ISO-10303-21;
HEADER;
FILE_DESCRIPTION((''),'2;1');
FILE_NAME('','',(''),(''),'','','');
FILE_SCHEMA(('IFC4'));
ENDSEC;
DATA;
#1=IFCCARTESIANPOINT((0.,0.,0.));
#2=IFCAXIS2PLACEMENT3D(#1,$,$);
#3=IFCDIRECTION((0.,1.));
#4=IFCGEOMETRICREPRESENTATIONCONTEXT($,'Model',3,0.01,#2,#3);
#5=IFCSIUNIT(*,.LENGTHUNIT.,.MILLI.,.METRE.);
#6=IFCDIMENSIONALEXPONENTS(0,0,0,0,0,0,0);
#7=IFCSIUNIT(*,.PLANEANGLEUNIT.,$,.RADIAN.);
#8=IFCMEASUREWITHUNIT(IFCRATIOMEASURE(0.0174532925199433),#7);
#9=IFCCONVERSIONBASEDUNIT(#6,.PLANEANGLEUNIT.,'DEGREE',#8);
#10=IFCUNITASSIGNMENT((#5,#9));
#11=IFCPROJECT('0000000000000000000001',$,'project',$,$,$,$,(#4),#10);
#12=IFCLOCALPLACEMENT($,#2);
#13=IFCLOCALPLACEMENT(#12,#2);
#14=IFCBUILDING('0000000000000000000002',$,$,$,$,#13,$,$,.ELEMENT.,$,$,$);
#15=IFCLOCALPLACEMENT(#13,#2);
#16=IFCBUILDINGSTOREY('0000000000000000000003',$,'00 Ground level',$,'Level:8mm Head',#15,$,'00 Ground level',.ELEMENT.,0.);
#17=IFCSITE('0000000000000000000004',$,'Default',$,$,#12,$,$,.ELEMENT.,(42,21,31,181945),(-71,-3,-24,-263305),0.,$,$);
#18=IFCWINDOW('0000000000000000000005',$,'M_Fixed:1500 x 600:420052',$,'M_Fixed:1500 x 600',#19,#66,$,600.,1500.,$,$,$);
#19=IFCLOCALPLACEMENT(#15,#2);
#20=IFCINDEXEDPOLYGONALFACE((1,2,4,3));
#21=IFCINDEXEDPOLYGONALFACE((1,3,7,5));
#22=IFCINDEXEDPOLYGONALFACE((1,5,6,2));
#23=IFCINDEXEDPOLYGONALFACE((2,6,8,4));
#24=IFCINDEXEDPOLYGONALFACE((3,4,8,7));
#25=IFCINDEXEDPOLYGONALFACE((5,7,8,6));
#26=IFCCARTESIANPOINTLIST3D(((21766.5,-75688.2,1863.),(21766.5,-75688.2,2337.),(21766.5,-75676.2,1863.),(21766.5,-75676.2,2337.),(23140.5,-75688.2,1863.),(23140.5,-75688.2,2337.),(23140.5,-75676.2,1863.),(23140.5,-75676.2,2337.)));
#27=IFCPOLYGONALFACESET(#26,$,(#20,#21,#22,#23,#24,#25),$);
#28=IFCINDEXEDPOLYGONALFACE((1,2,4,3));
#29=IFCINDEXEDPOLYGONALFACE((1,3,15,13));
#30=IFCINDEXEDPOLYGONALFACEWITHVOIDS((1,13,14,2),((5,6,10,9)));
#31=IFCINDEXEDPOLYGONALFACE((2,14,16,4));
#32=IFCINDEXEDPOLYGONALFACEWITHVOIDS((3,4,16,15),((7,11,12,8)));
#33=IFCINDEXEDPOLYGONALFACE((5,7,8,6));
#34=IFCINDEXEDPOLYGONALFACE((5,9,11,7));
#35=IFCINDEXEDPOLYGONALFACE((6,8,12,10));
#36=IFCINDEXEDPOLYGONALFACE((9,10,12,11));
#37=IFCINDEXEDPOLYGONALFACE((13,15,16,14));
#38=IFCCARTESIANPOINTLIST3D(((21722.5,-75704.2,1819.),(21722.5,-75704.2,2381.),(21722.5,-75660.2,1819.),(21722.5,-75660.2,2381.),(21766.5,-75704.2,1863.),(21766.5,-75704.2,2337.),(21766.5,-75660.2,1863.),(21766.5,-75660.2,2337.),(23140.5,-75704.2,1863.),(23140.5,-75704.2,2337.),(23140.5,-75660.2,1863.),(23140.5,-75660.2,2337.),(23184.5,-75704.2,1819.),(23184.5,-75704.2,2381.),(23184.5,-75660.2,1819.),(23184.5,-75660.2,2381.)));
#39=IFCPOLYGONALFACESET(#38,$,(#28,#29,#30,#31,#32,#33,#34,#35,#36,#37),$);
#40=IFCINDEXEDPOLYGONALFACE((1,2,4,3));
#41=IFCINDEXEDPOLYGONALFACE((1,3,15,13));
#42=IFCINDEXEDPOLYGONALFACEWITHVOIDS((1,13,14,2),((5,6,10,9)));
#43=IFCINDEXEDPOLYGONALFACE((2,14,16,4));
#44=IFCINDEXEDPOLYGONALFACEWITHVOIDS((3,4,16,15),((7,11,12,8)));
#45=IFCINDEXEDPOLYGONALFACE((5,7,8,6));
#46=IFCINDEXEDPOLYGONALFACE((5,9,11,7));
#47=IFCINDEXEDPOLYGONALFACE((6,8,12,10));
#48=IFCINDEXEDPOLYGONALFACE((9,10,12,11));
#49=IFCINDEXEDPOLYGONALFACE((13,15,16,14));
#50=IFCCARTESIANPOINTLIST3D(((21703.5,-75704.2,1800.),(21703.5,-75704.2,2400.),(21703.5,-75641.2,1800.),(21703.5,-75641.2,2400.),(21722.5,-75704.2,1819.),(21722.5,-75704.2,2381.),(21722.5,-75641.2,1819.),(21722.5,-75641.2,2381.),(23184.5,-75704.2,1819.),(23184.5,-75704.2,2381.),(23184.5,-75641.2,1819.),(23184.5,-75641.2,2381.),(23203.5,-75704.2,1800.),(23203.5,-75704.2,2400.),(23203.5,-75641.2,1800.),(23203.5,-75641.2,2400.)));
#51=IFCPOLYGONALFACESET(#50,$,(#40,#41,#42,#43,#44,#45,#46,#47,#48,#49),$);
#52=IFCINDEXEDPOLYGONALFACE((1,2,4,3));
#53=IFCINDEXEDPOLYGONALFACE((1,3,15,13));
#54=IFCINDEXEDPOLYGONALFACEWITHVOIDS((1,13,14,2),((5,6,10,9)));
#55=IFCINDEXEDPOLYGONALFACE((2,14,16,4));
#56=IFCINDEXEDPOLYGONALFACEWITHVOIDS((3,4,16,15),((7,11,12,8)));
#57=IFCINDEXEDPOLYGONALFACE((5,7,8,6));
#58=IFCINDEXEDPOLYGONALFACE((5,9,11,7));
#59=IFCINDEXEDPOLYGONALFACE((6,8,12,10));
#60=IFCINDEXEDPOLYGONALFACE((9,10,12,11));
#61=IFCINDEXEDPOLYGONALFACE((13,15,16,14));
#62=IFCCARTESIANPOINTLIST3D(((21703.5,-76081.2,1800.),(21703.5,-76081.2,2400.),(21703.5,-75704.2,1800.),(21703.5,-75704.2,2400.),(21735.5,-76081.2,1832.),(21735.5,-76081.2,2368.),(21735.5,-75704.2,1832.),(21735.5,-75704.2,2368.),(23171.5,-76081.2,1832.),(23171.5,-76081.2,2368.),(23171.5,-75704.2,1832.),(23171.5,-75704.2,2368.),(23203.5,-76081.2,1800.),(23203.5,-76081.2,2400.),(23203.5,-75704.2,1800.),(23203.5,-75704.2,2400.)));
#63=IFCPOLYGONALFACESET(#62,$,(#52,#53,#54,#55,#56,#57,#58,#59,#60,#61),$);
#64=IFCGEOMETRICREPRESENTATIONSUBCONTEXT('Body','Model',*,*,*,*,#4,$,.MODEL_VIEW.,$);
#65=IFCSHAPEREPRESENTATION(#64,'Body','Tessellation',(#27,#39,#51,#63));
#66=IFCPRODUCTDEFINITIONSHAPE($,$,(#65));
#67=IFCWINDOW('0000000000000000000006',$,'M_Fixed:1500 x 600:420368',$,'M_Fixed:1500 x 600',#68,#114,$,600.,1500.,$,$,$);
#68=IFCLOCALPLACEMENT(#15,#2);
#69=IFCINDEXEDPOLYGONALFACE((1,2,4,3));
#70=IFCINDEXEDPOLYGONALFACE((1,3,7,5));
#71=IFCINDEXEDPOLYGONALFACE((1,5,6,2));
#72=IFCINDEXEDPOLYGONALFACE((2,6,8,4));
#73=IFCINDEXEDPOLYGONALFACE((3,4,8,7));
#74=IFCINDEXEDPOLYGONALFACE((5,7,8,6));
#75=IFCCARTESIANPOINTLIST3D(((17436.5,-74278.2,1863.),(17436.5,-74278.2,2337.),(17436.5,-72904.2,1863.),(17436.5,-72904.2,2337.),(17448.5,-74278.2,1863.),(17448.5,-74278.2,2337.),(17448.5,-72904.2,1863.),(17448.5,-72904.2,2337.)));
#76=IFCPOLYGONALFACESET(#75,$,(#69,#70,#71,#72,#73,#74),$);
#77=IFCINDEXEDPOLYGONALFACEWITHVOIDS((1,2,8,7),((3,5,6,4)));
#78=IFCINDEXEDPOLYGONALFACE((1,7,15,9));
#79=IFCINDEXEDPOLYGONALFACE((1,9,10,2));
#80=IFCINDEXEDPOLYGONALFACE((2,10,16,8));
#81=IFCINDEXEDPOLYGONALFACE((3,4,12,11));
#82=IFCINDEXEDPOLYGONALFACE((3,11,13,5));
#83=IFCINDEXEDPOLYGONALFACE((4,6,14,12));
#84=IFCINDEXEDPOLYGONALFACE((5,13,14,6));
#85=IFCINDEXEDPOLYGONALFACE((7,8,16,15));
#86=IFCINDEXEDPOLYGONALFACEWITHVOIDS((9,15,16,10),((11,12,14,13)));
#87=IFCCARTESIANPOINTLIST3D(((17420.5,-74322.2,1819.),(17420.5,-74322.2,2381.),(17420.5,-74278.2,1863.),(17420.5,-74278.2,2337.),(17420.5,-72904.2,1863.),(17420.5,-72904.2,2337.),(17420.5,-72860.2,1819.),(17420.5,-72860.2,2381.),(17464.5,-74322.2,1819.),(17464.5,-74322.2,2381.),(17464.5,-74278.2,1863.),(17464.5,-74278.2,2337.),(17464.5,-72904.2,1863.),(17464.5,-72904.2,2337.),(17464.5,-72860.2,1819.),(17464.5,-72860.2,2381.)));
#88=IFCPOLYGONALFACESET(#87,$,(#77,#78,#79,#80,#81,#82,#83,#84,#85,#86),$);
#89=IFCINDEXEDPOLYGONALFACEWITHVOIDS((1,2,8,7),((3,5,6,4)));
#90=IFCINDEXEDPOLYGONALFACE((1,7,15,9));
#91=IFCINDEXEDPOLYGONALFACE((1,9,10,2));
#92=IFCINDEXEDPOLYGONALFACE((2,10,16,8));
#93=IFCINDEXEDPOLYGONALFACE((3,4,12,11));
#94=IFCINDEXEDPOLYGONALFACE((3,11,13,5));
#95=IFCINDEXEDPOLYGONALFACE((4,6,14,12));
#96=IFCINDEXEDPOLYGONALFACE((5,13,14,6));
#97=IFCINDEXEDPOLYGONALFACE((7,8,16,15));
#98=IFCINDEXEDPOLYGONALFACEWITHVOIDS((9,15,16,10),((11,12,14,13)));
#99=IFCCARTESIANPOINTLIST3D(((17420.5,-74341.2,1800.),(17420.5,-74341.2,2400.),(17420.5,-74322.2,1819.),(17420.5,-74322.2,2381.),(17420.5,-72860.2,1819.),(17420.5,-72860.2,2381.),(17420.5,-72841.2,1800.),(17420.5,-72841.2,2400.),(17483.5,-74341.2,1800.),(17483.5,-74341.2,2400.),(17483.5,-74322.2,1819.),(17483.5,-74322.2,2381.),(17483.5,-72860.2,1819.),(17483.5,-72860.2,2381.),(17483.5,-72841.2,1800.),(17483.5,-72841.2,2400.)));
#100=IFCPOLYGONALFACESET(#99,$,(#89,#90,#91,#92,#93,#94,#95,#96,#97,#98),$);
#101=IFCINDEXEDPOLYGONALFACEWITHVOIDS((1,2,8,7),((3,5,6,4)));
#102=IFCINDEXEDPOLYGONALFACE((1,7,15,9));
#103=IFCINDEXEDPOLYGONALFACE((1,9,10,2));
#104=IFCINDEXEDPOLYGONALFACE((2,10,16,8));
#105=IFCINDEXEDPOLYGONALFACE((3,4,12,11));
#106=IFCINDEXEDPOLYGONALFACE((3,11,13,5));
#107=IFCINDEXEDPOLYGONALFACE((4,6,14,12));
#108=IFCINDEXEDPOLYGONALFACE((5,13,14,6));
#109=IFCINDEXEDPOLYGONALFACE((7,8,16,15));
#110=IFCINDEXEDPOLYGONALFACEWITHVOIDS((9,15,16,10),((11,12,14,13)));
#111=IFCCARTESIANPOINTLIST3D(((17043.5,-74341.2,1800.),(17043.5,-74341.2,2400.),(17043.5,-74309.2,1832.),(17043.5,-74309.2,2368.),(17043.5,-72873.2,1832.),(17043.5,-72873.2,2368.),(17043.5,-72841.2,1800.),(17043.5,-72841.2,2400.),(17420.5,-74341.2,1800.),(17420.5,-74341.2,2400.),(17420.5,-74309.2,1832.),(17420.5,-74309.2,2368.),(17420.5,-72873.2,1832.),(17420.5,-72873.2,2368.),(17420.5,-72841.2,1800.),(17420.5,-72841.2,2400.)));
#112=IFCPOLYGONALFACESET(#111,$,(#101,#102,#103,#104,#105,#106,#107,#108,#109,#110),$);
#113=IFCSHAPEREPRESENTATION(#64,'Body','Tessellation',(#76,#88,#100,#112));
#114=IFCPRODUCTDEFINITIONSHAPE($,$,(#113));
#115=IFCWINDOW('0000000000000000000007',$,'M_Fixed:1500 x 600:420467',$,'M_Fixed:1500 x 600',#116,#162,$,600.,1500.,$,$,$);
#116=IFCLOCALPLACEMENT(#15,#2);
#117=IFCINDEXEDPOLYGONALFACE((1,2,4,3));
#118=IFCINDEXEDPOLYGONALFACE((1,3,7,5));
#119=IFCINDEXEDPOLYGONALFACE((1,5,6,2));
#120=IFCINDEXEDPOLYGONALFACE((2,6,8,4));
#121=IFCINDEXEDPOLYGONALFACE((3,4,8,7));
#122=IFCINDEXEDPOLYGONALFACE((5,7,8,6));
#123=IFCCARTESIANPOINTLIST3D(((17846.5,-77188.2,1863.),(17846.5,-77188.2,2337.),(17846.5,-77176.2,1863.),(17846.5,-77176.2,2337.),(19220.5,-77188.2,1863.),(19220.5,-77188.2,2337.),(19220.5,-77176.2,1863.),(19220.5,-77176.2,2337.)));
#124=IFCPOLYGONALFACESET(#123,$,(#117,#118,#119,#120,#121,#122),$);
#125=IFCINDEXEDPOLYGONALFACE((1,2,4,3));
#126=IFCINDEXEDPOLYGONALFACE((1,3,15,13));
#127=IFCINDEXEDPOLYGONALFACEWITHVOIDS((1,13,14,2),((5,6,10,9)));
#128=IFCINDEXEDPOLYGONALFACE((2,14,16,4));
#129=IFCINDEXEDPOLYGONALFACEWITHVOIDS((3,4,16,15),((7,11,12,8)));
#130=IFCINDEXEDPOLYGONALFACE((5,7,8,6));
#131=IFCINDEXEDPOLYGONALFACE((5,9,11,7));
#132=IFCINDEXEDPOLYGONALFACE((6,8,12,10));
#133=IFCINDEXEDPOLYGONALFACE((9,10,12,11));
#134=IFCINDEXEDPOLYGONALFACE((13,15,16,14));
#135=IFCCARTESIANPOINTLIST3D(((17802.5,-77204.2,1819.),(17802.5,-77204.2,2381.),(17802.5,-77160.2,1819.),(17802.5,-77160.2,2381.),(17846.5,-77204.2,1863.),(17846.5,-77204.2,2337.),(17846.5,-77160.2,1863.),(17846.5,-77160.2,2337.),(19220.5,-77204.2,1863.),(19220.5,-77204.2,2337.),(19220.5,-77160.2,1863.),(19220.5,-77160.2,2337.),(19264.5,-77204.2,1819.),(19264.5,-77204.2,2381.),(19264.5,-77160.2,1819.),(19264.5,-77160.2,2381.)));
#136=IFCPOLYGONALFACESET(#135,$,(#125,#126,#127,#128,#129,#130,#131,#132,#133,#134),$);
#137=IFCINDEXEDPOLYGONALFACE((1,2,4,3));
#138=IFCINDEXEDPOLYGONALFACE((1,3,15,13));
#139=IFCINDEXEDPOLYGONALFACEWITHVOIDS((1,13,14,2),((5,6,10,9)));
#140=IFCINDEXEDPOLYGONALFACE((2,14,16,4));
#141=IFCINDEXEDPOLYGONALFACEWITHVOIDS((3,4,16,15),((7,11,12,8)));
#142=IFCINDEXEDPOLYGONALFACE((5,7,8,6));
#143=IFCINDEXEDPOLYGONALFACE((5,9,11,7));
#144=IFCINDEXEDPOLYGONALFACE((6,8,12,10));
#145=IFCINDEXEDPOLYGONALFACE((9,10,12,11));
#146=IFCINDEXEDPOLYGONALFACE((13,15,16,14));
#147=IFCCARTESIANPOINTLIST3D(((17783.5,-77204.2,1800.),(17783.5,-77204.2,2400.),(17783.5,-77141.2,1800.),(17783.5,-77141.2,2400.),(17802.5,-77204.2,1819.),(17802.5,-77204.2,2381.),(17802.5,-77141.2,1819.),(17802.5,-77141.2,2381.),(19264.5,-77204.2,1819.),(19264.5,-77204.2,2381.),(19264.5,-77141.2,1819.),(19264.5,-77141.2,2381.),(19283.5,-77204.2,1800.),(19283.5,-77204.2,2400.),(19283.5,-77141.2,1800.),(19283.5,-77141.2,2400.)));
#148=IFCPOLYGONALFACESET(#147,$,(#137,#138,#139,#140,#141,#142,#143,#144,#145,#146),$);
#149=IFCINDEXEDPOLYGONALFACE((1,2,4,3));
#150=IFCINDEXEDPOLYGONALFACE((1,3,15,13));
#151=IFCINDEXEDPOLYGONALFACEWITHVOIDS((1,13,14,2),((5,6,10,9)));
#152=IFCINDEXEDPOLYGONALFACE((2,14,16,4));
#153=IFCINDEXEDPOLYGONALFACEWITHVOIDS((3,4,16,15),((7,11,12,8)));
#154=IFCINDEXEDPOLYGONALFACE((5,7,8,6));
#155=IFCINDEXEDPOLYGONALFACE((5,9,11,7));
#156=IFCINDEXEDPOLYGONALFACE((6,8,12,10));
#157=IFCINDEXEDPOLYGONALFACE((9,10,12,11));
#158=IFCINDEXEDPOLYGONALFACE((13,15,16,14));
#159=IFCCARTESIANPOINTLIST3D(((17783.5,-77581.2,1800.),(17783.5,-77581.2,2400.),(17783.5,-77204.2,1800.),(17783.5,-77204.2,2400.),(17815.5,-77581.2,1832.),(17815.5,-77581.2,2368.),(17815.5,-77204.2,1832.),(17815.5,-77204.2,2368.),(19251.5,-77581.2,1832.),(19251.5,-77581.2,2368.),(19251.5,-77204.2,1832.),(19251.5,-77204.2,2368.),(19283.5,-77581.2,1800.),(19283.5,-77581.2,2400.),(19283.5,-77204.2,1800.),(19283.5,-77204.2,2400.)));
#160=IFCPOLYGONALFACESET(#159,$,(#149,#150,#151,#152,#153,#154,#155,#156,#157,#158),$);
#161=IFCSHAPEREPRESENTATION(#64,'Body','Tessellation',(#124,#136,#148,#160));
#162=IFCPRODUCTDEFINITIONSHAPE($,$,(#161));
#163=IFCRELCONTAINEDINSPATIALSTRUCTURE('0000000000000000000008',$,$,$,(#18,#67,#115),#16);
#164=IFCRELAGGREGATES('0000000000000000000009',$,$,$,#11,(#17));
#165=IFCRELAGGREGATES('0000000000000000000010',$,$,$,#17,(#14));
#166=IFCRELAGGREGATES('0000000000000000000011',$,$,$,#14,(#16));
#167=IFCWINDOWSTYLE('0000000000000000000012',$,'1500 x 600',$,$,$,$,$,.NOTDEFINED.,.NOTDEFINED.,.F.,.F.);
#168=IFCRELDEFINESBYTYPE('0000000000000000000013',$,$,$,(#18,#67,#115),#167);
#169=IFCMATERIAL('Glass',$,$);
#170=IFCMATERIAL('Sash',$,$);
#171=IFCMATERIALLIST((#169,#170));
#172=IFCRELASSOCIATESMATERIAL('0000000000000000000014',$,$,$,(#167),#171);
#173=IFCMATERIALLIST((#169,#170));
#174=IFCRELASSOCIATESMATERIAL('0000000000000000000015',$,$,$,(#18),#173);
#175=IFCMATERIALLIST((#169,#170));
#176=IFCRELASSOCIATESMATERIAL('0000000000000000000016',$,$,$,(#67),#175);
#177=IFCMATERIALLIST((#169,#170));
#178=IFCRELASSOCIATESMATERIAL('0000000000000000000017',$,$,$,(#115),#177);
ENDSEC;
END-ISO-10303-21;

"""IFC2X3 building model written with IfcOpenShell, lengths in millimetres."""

from ifc_helpers import new_model, entity, si_unit, converted_unit, direction, frame, origin, origin_2d_with_axis, place, context, subcontext, project, spatial, polyline, rectangle, outline, extrude, source, transform, mapped, material, material_list, type_object, type_shapes, element, save


model = new_model("IFC2X3")

# Units and contexts
model_context = context("Model", 3, precision=0.01, world=origin(), true_north=direction((0.0, 1.0)))
body_context = subcontext(model_context, "Body", "Model", "MODEL_VIEW")
ifc_project = project(units=[si_unit("LENGTHUNIT", "METRE", prefix="MILLI"), converted_unit("PLANEANGLEUNIT", "DEGREE", entity("IfcRatioMeasure", 0.0174532925199433), si_unit("PLANEANGLEUNIT", "RADIAN"), dimensions=[0, 0, 0, 0, 0, 0, 0])], contexts=[model_context])

# Site, building, storey
site_placement = place(None, origin())
site = spatial("IfcSite", under=ifc_project, at=site_placement, Name="Default", CompositionType="ELEMENT", RefLatitude=(42, 21, 31, 181945), RefLongitude=(-71, -3, -24, -263305), RefElevation=0.0)
building_placement = place(site_placement, origin())
building = spatial("IfcBuilding", under=site, at=building_placement, CompositionType="ELEMENT")
storey_placement = place(building_placement, origin())
storey = spatial("IfcBuildingStorey", under=building, at=storey_placement, Name="00 Ground level", ObjectType="Level:8mm Head", LongName="00 Ground level", CompositionType="ELEMENT", Elevation=0.0)

# Windows
ifc_material_1 = material(Name="Glass")
ifc_material_2 = material(Name="Sash")
ifc_material_list_1 = material_list([ifc_material_1, ifc_material_2])
window_style_1 = type_object("IfcWindowStyle", Name="1500 x 600", ConstructionType="NOTDEFINED", OperationType="NOTDEFINED", ParameterTakesPrecedence=False, Sizeable=False, material=ifc_material_list_1)
shared_shape_1 = source(origin(), body_context, "Body", "SweptSolid", [
    extrude(rectangle(XDim=12.0, YDim=1374.0, at=origin_2d_with_axis()), frame((750.0, 399.0, 63.0), z_axis=(0.0, 0.0, 1.0), x_axis=(0.0, -1.0, 0.0)), (0.0, 0.0, 1.0), 474.0),
    extrude(outline(polyline([(-731.0, -281.0), (731.0, -281.0), (731.0, 281.0), (-731.0, 281.0), (-731.0, -281.0)]), holes=[polyline([(-687.0, -237.0), (-687.0, 237.0), (687.0, 237.0), (687.0, -237.0), (-687.0, -237.0)])]), frame((750.0, 377.0, 300.0), z_axis=(0.0, 1.0, 0.0), x_axis=(1.0, 0.0, 0.0)), (0.0, 0.0, 1.0), 44.0),
    extrude(outline(polyline([(-750.0, -300.0), (750.0, -300.0), (750.0, 300.0), (-750.0, 300.0), (-750.0, -300.0)]), holes=[polyline([(-731.0, -281.0), (-731.0, 281.0), (731.0, 281.0), (731.0, -281.0), (-731.0, -281.0)])]), frame((750.0, 377.0, 300.0), z_axis=(0.0, 1.0, 0.0), x_axis=(1.0, 0.0, 0.0)), (0.0, 0.0, 1.0), 63.0),
    extrude(outline(polyline([(-750.0, -300.0), (750.0, -300.0), (750.0, 300.0), (-750.0, 300.0), (-750.0, -300.0)]), holes=[polyline([(-718.0, -268.0), (-718.0, 268.0), (718.0, 268.0), (718.0, -268.0), (-718.0, -268.0)])]), frame((750.0, 0.0, 300.0), z_axis=(0.0, 1.0, 0.0), x_axis=(1.0, 0.0, 0.0)), (0.0, 0.0, 1.0), 377.0),
])
type_shapes(window_style_1, [shared_shape_1])
ifc_material_list_2 = material_list([ifc_material_1, ifc_material_2])
window_1_placement = place(storey_placement, frame((21703.5, -76081.2, 1800.0)))
element("IfcWindow", 1, at=window_1_placement, inside=storey, type_object=window_style_1, material=ifc_material_list_2, Name="M_Fixed:1500 x 600:420052", ObjectType="M_Fixed:1500 x 600", OverallHeight=600.0, OverallWidth=1500.0, context=body_context, shape_type="MappedRepresentation", body=[
    mapped(shared_shape_1, transform((0.0, 0.0, 0.0), scale=1.0)),
])
ifc_material_list_3 = material_list([ifc_material_1, ifc_material_2])
window_2_placement = place(storey_placement, frame((17043.5, -72841.2, 1800.0), z_axis=(0.0, 0.0, 1.0), x_axis=(0.0, -1.0, 0.0)))
element("IfcWindow", 2, at=window_2_placement, inside=storey, type_object=window_style_1, material=ifc_material_list_3, Name="M_Fixed:1500 x 600:420368", ObjectType="M_Fixed:1500 x 600", OverallHeight=600.0, OverallWidth=1500.0, context=body_context, shape_type="MappedRepresentation", body=[
    mapped(shared_shape_1, transform((0.0, 0.0, 0.0), scale=1.0)),
])
ifc_material_list_4 = material_list([ifc_material_1, ifc_material_2])
window_3_placement = place(storey_placement, frame((17783.5, -77581.2, 1800.0)))
element("IfcWindow", 3, at=window_3_placement, inside=storey, type_object=window_style_1, material=ifc_material_list_4, Name="M_Fixed:1500 x 600:420467", ObjectType="M_Fixed:1500 x 600", OverallHeight=600.0, OverallWidth=1500.0, context=body_context, shape_type="MappedRepresentation", body=[
    mapped(shared_shape_1, transform((0.0, 0.0, 0.0), scale=1.0)),
])

save(model, "model.ifc")
